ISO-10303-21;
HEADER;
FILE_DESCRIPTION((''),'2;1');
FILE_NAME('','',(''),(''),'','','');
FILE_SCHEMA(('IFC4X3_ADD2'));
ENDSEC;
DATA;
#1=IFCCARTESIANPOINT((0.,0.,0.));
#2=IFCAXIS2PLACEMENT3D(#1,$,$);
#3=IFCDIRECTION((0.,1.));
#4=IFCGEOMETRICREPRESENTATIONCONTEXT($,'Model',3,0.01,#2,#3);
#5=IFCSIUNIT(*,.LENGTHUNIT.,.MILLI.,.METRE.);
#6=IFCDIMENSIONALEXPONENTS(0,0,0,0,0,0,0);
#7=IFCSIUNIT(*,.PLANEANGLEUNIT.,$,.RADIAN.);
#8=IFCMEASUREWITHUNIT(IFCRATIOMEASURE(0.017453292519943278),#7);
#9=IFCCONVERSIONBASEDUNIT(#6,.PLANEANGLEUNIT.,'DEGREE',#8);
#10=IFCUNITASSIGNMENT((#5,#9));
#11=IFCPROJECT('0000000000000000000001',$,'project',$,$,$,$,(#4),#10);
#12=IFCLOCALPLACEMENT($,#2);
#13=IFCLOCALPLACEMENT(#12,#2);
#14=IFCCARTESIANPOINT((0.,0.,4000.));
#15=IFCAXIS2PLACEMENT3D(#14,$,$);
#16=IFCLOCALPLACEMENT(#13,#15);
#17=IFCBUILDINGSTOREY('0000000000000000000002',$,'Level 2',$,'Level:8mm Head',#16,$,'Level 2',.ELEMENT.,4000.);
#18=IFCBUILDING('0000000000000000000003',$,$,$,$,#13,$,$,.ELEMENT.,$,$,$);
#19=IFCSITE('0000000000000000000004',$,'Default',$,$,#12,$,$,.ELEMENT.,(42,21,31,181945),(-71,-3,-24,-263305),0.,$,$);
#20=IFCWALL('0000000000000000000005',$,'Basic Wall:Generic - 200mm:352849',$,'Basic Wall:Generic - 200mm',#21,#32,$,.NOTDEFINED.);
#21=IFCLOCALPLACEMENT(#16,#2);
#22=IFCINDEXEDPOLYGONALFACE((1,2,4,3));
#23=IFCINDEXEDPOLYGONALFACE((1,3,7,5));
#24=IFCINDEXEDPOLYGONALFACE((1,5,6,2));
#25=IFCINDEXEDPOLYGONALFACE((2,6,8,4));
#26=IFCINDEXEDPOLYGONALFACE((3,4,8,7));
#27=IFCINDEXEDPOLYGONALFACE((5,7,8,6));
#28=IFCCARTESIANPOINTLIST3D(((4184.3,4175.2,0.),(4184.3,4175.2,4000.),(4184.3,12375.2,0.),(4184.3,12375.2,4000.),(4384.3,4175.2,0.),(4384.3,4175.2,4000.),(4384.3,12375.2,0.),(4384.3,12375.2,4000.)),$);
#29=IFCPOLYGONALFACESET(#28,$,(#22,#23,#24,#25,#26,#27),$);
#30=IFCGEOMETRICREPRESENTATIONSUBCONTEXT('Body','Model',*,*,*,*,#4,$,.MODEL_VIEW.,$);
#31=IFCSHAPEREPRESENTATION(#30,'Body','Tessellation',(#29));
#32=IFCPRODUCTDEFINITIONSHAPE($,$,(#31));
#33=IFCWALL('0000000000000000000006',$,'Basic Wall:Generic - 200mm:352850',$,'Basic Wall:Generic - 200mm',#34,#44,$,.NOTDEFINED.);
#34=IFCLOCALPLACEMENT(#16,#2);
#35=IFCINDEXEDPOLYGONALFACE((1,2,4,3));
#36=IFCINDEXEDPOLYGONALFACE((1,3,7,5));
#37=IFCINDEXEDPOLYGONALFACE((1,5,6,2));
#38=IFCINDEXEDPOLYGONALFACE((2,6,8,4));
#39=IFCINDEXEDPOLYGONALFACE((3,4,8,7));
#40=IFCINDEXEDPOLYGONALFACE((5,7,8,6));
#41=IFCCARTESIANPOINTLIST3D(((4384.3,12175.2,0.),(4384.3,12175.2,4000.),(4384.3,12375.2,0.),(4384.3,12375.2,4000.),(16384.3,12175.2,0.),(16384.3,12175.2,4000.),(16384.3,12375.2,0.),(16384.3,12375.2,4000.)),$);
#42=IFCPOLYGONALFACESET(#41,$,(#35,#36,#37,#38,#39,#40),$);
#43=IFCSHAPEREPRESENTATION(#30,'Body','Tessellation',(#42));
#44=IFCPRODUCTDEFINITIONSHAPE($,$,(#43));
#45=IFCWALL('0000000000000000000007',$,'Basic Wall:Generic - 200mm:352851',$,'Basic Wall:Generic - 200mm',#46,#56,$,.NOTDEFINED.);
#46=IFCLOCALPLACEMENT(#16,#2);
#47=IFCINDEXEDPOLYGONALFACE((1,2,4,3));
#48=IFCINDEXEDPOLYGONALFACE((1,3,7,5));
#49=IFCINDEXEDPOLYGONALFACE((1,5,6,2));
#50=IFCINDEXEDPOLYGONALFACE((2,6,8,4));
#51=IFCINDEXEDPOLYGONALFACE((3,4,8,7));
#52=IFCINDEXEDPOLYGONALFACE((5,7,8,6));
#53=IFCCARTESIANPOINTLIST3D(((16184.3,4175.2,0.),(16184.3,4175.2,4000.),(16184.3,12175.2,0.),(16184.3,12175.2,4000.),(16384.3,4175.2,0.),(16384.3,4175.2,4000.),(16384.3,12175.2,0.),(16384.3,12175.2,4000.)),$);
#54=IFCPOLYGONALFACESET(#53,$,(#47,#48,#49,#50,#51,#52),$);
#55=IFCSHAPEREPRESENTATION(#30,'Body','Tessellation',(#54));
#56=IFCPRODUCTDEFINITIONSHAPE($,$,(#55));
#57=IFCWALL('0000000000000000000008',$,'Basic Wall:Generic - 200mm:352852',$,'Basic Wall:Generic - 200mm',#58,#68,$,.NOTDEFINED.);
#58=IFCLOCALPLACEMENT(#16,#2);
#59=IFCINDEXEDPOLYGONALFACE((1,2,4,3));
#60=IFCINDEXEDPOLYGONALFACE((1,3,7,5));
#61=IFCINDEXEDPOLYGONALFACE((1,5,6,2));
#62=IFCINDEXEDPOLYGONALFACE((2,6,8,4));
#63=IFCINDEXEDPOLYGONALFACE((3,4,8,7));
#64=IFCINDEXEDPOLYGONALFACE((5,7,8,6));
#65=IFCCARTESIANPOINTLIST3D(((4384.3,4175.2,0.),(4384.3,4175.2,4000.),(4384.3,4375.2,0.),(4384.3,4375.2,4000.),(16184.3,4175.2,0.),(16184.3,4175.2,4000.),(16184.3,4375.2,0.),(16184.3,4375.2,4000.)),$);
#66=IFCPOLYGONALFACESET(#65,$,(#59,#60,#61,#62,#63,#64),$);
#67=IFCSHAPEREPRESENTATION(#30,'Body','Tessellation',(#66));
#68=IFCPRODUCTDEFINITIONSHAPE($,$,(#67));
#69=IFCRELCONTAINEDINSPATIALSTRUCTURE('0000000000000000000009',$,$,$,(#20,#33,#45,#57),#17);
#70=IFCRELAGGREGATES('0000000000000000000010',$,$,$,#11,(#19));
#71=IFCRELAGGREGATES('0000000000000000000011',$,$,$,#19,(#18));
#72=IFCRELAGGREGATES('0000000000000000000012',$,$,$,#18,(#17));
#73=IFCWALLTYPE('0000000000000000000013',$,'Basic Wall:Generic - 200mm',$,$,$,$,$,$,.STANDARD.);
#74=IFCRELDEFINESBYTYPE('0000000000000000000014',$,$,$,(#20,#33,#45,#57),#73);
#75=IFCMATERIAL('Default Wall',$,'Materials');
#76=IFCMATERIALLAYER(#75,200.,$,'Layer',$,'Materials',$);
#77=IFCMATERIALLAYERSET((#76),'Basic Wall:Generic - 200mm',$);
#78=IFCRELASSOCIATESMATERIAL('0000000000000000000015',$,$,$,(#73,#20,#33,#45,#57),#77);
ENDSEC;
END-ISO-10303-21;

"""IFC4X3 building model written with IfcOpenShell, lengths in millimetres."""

from ifc_helpers import new_model, entity, si_unit, converted_unit, direction, frame, frame_2d, origin, place, context, subcontext, project, spatial, rectangle, extrude, material, layer, layer_set, type_object, element, save


model = new_model("IFC4X3")

# Units and contexts
model_context = context("Model", 3, precision=0.01, world=origin(), true_north=direction((0.0, 1.0)))
body_context = subcontext(model_context, "Body", "Model", "MODEL_VIEW")
ifc_project = project(units=[si_unit("LENGTHUNIT", "METRE", prefix="MILLI"), converted_unit("PLANEANGLEUNIT", "DEGREE", entity("IfcRatioMeasure", 0.017453292519943278), si_unit("PLANEANGLEUNIT", "RADIAN"), dimensions=[0, 0, 0, 0, 0, 0, 0])], contexts=[model_context])

# Site, building, storey
site_placement = place(None, origin())
site = spatial("IfcSite", under=ifc_project, at=site_placement, Name="Default", CompositionType="ELEMENT", RefLatitude=(42, 21, 31, 181945), RefLongitude=(-71, -3, -24, -263305), RefElevation=0.0)
building_placement = place(site_placement, origin())
building = spatial("IfcBuilding", under=site, at=building_placement, CompositionType="ELEMENT")
storey_placement = place(building_placement, frame((0.0, 0.0, 4000.0)))
storey = spatial("IfcBuildingStorey", under=building, at=storey_placement, Name="Level 2", ObjectType="Level:8mm Head", LongName="Level 2", CompositionType="ELEMENT", Elevation=4000.0)

# Walls
ifc_material = material(Name="Default Wall", Category="Materials")
ifc_layer = layer(ifc_material, 200.0, Name="Layer", Category="Materials")
ifc_layer_set = layer_set([ifc_layer], Name="Basic Wall:Generic - 200mm")
wall_type = type_object("IfcWallType", Name="Basic Wall:Generic - 200mm", PredefinedType="STANDARD", material=ifc_layer_set)
wall_1_placement = place(storey_placement, frame((4284.3, 4175.2, 0.0), z_axis=(0.0, 0.0, 1.0), x_axis=(0.0, 1.0, 0.0)))
element("IfcWall", 1, at=wall_1_placement, inside=storey, type_object=wall_type, material=ifc_layer_set, Name="Basic Wall:Generic - 200mm:352849", ObjectType="Basic Wall:Generic - 200mm", PredefinedType="NOTDEFINED", context=body_context, shape_type="SweptSolid", body=[
    extrude(rectangle(XDim=8200.0, YDim=200.0, at=frame_2d((4100.0, 0.0), x_axis=(-1.0, 0.0))), origin(), (0.0, 0.0, 1.0), 4000.0),
])
wall_2_placement = place(storey_placement, frame((4384.3, 12275.2, 0.0)))
element("IfcWall", 2, at=wall_2_placement, inside=storey, type_object=wall_type, material=ifc_layer_set, Name="Basic Wall:Generic - 200mm:352850", ObjectType="Basic Wall:Generic - 200mm", PredefinedType="NOTDEFINED", context=body_context, shape_type="SweptSolid", body=[
    extrude(rectangle(XDim=12000.0, YDim=200.0, at=frame_2d((6000.0, 0.0), x_axis=(-1.0, 0.0))), origin(), (0.0, 0.0, 1.0), 4000.0),
])
wall_3_placement = place(storey_placement, frame((16284.3, 12175.2, 0.0), z_axis=(0.0, 0.0, 1.0), x_axis=(0.0, -1.0, 0.0)))
element("IfcWall", 3, at=wall_3_placement, inside=storey, type_object=wall_type, material=ifc_layer_set, Name="Basic Wall:Generic - 200mm:352851", ObjectType="Basic Wall:Generic - 200mm", PredefinedType="NOTDEFINED", context=body_context, shape_type="SweptSolid", body=[
    extrude(rectangle(XDim=8000.0, YDim=200.0, at=frame_2d((4000.0, 0.0), x_axis=(-1.0, 0.0))), origin(), (0.0, 0.0, 1.0), 4000.0),
])
wall_4_placement = place(storey_placement, frame((16184.3, 4275.2, 0.0), z_axis=(0.0, 0.0, 1.0), x_axis=(-1.0, 0.0, 0.0)))
element("IfcWall", 4, at=wall_4_placement, inside=storey, type_object=wall_type, material=ifc_layer_set, Name="Basic Wall:Generic - 200mm:352852", ObjectType="Basic Wall:Generic - 200mm", PredefinedType="NOTDEFINED", context=body_context, shape_type="SweptSolid", body=[
    extrude(rectangle(XDim=11800.0, YDim=200.0, at=frame_2d((5900.0, 0.0), x_axis=(-1.0, 0.0))), origin(), (0.0, 0.0, 1.0), 4000.0),
])

save(model, "model.ifc")
